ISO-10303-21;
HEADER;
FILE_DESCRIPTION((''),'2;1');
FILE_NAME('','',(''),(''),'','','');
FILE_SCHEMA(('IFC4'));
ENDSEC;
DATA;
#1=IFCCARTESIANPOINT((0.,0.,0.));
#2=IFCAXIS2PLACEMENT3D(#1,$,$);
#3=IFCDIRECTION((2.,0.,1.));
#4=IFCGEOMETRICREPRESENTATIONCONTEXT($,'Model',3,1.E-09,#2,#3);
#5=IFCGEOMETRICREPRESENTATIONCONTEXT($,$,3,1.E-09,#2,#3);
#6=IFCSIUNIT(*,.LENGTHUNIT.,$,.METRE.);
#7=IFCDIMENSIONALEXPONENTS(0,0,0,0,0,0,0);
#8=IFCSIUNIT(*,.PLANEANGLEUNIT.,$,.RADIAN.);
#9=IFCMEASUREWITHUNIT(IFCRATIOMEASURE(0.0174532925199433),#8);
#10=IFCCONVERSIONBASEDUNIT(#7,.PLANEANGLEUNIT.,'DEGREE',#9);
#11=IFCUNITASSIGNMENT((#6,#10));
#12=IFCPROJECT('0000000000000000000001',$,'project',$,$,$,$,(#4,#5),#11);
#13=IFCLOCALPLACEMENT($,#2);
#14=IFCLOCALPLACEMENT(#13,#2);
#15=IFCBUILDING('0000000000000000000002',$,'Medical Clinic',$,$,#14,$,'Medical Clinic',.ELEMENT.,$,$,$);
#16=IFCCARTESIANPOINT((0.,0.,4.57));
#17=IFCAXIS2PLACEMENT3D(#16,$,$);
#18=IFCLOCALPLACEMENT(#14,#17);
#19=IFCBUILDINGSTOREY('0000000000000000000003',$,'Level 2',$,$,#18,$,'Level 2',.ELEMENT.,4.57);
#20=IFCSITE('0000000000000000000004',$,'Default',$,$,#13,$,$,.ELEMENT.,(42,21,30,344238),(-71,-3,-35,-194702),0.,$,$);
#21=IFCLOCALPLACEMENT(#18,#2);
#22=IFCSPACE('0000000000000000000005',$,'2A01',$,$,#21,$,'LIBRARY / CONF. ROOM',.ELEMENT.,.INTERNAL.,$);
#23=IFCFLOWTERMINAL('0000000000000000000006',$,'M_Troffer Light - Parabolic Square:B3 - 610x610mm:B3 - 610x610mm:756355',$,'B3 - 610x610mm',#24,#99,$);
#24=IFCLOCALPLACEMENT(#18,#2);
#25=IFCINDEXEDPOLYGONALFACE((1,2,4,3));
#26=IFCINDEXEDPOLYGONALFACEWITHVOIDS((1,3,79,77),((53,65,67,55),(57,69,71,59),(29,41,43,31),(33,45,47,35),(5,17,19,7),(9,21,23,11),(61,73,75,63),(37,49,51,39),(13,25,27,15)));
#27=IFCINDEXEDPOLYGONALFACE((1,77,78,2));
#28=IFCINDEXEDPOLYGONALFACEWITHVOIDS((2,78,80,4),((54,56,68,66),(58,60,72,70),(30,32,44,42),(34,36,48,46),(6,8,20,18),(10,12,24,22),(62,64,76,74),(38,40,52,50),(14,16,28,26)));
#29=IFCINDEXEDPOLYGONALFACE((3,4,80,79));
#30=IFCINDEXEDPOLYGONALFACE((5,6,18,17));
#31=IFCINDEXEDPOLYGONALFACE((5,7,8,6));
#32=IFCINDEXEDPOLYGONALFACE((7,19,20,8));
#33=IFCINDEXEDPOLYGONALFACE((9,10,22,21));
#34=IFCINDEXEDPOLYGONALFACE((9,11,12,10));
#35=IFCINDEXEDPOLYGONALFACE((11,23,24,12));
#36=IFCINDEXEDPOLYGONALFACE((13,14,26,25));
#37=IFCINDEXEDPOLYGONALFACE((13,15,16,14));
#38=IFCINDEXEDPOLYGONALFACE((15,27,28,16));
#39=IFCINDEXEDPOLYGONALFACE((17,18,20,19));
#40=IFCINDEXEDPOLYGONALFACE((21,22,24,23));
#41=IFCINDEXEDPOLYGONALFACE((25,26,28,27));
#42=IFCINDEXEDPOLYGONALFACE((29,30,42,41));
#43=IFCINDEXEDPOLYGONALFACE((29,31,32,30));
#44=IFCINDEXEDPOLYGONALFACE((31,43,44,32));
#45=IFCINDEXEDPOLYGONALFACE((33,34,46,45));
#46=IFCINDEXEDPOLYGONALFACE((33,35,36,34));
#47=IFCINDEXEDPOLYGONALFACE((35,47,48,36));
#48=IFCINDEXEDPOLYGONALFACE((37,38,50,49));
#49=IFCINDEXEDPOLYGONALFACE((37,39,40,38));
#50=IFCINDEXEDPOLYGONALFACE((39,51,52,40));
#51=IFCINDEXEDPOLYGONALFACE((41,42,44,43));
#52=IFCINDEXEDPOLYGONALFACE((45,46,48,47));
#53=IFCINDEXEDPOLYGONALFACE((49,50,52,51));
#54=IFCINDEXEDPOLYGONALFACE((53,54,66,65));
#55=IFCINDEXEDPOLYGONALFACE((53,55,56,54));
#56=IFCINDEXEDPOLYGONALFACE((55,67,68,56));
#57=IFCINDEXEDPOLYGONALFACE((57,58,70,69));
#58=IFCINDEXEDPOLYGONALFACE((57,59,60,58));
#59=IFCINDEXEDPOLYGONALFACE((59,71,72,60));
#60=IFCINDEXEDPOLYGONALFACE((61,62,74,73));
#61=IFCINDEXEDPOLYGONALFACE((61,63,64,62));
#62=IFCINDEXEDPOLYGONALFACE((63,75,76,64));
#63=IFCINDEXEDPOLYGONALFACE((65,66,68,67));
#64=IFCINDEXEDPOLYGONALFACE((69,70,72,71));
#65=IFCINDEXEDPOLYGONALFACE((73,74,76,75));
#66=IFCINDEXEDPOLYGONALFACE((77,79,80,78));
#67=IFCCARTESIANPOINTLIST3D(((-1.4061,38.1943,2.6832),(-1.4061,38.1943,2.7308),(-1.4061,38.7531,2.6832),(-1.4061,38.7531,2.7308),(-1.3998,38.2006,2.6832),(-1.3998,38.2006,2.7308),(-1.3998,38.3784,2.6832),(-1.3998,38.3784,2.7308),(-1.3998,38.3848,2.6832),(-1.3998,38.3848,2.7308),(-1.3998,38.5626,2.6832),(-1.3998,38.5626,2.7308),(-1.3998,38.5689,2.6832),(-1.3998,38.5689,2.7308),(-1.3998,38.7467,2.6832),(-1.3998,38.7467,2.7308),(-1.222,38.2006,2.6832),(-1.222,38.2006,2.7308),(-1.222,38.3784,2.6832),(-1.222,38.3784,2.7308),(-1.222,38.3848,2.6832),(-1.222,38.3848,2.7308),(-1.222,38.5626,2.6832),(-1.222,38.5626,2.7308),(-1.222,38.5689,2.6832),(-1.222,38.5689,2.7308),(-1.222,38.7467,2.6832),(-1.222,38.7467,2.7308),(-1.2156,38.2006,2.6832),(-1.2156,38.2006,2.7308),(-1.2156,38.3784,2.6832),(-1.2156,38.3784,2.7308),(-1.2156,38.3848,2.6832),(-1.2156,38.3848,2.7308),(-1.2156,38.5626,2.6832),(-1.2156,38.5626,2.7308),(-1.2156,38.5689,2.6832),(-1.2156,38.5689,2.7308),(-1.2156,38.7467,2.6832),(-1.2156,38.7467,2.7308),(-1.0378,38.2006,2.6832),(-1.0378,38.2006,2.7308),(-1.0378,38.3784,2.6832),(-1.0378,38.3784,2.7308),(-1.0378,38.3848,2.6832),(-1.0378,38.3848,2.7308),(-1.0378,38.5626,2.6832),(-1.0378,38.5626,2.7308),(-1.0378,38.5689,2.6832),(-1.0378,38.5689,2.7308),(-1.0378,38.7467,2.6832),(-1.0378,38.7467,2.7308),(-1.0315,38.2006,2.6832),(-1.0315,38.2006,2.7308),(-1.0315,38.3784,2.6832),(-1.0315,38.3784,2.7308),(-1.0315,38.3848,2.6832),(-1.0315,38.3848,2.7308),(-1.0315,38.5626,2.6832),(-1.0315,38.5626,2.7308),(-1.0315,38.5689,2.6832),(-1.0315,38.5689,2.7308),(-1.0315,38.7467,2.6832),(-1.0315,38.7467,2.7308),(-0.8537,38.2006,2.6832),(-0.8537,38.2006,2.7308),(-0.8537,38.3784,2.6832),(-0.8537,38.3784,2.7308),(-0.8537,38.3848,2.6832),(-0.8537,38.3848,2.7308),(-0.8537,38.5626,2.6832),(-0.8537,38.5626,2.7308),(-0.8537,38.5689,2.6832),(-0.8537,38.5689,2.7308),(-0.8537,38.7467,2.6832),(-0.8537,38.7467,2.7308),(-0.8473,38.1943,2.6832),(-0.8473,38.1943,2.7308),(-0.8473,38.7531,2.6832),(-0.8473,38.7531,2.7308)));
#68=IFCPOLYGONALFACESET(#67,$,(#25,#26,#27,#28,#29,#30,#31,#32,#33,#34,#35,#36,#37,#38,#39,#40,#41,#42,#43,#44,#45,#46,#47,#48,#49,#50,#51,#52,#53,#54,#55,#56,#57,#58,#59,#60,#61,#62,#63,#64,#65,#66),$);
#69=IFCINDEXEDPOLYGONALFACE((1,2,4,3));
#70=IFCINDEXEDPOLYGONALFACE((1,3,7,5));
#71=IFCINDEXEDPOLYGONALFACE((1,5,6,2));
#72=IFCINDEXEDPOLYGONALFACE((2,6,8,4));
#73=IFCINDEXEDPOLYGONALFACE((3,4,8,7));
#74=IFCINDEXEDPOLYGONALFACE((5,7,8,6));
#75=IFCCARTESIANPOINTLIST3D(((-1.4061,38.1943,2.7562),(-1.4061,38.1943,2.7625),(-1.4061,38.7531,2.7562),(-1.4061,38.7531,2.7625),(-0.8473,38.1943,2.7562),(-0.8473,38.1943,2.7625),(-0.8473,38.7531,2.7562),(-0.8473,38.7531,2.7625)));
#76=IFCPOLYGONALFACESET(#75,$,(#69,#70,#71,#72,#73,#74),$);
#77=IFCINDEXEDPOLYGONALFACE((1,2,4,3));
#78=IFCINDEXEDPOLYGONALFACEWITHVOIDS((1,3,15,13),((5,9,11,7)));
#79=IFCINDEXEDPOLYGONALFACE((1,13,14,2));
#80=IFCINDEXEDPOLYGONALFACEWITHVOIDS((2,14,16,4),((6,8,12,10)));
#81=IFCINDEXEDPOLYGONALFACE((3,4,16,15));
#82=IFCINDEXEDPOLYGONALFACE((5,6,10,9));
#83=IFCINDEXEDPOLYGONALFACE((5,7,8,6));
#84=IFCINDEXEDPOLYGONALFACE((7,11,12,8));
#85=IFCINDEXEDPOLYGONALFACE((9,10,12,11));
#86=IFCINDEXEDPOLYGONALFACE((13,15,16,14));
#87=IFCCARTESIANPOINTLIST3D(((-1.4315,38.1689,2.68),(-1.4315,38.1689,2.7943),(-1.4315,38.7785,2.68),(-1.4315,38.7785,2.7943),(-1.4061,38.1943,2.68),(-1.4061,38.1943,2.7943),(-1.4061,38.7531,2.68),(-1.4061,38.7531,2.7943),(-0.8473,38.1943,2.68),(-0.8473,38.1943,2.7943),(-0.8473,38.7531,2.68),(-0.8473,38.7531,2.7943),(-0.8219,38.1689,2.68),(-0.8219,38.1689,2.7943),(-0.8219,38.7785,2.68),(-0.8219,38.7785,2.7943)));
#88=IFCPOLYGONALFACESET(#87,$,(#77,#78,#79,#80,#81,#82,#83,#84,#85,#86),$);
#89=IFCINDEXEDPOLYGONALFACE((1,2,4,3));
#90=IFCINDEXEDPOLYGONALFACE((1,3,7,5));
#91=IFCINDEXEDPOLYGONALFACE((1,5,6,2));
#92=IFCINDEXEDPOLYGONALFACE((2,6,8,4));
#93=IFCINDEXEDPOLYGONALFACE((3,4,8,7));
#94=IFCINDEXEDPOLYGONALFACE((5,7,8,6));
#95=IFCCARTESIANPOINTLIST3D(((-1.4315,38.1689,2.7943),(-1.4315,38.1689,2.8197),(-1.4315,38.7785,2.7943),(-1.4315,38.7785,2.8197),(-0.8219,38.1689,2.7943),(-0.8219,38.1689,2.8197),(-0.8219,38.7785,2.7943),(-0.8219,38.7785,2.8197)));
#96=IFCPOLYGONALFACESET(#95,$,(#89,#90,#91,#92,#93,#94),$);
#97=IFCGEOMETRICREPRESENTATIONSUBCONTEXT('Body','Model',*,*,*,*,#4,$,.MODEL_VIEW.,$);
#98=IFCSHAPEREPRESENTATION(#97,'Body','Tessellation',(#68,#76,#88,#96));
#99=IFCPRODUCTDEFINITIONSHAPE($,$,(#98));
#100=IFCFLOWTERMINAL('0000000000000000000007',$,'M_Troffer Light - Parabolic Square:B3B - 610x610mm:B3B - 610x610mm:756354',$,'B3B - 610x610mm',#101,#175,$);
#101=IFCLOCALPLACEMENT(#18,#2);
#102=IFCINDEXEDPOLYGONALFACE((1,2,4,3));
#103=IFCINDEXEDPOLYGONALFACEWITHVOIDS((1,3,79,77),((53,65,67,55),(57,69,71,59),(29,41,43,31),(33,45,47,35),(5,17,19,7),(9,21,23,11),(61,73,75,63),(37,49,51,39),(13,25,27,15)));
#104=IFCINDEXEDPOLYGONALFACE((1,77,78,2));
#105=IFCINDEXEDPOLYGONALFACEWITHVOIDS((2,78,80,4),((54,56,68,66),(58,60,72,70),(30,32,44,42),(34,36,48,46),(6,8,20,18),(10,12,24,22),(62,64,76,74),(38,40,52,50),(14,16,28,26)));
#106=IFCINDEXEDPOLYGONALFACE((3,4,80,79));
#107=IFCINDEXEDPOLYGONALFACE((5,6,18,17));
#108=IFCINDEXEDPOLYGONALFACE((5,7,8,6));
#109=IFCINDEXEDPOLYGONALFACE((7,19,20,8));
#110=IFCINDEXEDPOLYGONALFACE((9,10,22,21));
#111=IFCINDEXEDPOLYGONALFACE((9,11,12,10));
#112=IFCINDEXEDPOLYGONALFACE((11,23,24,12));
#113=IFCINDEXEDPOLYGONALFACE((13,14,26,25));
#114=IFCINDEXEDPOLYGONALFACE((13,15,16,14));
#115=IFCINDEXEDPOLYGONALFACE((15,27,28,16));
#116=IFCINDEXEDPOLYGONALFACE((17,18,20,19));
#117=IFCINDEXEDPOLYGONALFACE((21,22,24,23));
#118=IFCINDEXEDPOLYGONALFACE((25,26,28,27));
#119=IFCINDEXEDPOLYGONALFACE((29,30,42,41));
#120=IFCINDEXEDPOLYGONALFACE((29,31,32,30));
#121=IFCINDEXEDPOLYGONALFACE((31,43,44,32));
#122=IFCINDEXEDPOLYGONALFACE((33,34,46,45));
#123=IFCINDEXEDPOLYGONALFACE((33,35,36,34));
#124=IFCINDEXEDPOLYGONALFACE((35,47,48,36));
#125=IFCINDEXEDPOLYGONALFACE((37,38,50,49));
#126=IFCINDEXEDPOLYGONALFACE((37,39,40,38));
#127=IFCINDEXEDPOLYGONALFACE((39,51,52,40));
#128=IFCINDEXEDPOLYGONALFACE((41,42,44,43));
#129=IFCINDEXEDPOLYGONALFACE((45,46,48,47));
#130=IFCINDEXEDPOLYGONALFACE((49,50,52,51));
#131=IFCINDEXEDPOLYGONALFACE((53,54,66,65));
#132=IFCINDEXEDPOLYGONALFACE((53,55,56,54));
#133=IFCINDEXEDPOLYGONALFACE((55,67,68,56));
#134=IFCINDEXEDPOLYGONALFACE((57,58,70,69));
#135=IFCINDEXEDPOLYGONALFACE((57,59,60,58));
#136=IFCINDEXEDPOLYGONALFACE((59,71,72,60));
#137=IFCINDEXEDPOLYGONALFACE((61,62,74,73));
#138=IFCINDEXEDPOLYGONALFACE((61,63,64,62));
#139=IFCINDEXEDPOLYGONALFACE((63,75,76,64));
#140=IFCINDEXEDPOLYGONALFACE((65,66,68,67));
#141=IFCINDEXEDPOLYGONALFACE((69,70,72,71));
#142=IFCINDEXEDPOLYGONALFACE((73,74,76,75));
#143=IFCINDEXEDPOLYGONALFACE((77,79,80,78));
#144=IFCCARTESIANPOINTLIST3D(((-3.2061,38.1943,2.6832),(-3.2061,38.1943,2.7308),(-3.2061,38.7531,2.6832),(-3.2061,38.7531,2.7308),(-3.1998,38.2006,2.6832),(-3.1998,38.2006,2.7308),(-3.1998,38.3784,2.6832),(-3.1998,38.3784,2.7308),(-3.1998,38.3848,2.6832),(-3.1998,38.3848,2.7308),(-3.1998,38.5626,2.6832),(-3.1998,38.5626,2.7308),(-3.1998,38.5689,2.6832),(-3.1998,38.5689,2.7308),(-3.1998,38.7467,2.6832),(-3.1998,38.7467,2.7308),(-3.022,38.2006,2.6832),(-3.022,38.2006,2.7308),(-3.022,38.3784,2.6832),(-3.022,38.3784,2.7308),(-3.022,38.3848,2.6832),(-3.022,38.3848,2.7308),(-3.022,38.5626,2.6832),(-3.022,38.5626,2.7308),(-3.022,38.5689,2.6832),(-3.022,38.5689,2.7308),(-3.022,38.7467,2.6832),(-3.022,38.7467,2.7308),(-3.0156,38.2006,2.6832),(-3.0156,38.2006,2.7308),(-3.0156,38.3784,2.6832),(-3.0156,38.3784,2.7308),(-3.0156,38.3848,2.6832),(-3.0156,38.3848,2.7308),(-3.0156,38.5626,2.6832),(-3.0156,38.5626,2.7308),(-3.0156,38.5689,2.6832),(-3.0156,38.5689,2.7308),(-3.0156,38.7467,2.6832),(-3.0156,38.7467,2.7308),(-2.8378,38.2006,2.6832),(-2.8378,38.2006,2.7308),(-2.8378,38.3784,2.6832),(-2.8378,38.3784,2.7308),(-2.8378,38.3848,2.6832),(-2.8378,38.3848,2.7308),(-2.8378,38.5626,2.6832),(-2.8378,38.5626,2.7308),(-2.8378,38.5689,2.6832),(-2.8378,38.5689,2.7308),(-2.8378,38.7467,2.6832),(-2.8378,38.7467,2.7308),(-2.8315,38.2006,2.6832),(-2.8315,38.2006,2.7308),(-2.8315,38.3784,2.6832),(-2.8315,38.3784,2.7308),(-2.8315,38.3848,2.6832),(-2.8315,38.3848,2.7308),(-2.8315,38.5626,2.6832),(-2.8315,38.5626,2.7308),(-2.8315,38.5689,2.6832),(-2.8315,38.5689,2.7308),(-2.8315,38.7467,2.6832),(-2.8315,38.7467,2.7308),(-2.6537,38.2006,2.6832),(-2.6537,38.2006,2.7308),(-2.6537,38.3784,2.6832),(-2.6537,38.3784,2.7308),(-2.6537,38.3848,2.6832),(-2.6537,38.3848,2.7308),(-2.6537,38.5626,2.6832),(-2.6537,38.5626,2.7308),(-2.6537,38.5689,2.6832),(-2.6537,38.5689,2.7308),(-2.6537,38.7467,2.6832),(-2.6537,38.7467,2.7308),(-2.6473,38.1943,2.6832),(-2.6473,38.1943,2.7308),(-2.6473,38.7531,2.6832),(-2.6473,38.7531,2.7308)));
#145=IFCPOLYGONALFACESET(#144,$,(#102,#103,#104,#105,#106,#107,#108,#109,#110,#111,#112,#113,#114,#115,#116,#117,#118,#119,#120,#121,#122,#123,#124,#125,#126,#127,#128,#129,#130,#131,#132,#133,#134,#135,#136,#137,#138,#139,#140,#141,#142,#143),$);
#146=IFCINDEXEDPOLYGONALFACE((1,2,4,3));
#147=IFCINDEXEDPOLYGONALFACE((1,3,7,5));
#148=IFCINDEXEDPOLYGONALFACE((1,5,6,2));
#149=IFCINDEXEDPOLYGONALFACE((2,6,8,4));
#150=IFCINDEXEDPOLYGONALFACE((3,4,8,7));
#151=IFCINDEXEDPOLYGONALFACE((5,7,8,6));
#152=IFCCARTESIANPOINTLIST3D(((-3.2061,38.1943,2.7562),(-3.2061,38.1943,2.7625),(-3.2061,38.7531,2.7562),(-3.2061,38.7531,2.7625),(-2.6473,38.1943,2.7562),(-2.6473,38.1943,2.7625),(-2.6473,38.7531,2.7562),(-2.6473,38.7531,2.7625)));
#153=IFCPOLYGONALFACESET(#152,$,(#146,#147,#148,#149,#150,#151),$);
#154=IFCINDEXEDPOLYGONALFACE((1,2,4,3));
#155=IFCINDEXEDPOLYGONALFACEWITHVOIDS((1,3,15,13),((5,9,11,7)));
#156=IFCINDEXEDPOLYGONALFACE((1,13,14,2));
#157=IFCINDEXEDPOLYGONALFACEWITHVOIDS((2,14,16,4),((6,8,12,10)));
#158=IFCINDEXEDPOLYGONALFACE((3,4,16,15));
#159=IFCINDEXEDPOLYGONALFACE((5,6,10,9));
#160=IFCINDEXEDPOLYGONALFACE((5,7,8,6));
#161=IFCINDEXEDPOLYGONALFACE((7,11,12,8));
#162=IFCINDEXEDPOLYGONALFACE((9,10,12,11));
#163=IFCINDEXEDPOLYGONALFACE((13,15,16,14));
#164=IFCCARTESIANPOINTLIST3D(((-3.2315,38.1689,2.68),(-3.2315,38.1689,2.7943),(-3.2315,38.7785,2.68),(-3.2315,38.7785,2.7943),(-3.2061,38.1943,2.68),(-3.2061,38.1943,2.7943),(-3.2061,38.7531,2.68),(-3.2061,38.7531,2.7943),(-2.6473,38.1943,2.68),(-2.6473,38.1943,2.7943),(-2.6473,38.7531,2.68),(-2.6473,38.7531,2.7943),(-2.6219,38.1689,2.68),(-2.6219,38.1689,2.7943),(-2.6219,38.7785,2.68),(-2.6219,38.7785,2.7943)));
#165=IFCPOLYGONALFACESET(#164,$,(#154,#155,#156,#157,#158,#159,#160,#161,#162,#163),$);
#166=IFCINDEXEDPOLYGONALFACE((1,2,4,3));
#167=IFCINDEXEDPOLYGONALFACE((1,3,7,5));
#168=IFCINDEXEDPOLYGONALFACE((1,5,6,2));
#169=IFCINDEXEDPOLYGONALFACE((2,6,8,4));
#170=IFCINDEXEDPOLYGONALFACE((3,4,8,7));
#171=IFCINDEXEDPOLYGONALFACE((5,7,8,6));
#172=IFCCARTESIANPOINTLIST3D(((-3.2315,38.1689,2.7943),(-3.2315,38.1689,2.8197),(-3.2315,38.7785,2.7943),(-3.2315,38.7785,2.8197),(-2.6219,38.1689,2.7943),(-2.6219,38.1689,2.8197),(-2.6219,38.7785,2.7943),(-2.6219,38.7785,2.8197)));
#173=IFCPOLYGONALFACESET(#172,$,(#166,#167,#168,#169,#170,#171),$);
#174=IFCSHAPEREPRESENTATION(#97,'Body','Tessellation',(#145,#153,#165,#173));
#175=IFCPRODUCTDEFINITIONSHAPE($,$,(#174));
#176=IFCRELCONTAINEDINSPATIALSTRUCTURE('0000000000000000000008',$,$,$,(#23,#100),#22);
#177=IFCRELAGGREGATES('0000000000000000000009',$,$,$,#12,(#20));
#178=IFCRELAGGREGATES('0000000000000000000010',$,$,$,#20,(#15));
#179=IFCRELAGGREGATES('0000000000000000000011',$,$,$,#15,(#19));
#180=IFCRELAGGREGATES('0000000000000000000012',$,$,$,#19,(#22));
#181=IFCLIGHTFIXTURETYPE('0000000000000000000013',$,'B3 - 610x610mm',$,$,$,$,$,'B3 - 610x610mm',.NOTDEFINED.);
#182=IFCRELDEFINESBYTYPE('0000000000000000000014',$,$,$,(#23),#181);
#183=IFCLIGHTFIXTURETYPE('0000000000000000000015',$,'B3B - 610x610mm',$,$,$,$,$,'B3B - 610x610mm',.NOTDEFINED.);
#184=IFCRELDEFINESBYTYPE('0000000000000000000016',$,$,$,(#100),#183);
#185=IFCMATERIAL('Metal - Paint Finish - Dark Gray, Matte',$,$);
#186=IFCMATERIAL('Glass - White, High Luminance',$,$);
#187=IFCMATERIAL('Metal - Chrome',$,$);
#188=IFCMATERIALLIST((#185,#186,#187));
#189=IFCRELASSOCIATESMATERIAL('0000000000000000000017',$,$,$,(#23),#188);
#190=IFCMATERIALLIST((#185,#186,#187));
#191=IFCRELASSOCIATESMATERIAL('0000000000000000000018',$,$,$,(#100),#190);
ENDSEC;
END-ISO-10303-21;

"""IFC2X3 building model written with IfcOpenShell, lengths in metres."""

from ifc_helpers import new_model, entity, si_unit, converted_unit, direction, frame, origin, origin_2d_with_axis, place, context, subcontext, project, spatial, polyline, rectangle, outline, extrude, source, transform, mapped, material, material_list, type_object, type_shapes, element, save


model = new_model("IFC2X3")

# Units and contexts
model_context = context("Model", 3, precision=1e-09, world=origin(), true_north=direction((2.0, 0.0, 1.0)))
context_of_model = context(None, 3, precision=1e-09, world=origin(), true_north=direction((2.0, 0.0, 1.0)))
body_context = subcontext(model_context, "Body", "Model", "MODEL_VIEW")
ifc_project = project(units=[si_unit("LENGTHUNIT", "METRE"), converted_unit("PLANEANGLEUNIT", "DEGREE", entity("IfcRatioMeasure", 0.0174532925199433), si_unit("PLANEANGLEUNIT", "RADIAN"), dimensions=[0, 0, 0, 0, 0, 0, 0])], contexts=[model_context, context_of_model])

# Site, building, storey, space
site_placement = place(None, origin())
site = spatial("IfcSite", under=ifc_project, at=site_placement, Name="Default", CompositionType="ELEMENT", RefLatitude=(42, 21, 30, 344238), RefLongitude=(-71, -3, -35, -194702), RefElevation=0.0)
building_placement = place(site_placement, origin())
building = spatial("IfcBuilding", under=site, at=building_placement, Name="Medical Clinic", LongName="Medical Clinic", CompositionType="ELEMENT")
storey_placement = place(building_placement, frame((0.0, 0.0, 4.57)))
storey = spatial("IfcBuildingStorey", under=building, at=storey_placement, Name="Level 2", LongName="Level 2", CompositionType="ELEMENT", Elevation=4.57)
space_1_placement = place(storey_placement, origin())
space_1 = spatial("IfcSpace", under=storey, at=space_1_placement, Name="2A01", LongName="LIBRARY / CONF. ROOM", CompositionType="ELEMENT", InteriorOrExteriorSpace="INTERNAL")

# Flow terminals
ifc_material_1 = material(Name="Metal - Paint Finish - Dark Gray, Matte")
ifc_material_2 = material(Name="Glass - White, High Luminance")
ifc_material_3 = material(Name="Metal - Chrome")
light_fixture_type_1 = type_object("IfcLightFixtureType", Name="B3 - 610x610mm", ElementType="B3 - 610x610mm", PredefinedType="NOTDEFINED")
shared_shape_1 = source(origin(), body_context, "Body", "SweptSolid", [
    extrude(outline(polyline([(-0.2794, -0.2794), (0.2794, -0.2794), (0.2794, 0.2794), (-0.2794, 0.2794), (-0.2794, -0.2794)]), holes=[polyline([(-0.0952, 0.0953), (-0.273, 0.0953), (-0.273, 0.2731), (-0.0952, 0.2731), (-0.0952, 0.0953)]), polyline([(0.2731, 0.0953), (0.0953, 0.0953), (0.0953, 0.2731), (0.2731, 0.2731), (0.2731, 0.0953)]), polyline([(-0.0889, 0.2731), (0.0889, 0.2731), (0.0889, 0.0953), (-0.0889, 0.0953), (-0.0889, 0.2731)]), polyline([(0.2731, -0.273), (0.0953, -0.273), (0.0953, -0.0952), (0.2731, -0.0952), (0.2731, -0.273)]), polyline([(0.0889, -0.273), (-0.0889, -0.273), (-0.0889, -0.0952), (0.0889, -0.0952), (0.0889, -0.273)]), polyline([(-0.0952, -0.273), (-0.273, -0.273), (-0.273, -0.0952), (-0.0952, -0.0952), (-0.0952, -0.273)]), polyline([(-0.0952, -0.0889), (-0.273, -0.0889), (-0.273, 0.0889), (-0.0952, 0.0889), (-0.0952, -0.0889)]), polyline([(0.0889, -0.0889), (-0.0889, -0.0889), (-0.0889, 0.0889), (0.0889, 0.0889), (0.0889, -0.0889)]), polyline([(0.2731, -0.0889), (0.0953, -0.0889), (0.0953, 0.0889), (0.2731, 0.0889), (0.2731, -0.0889)])]), frame((0.0, -0.3048, -0.0508), z_axis=(0.0, 0.0, 1.0), x_axis=(-1.0, 0.0, 0.0)), (0.0, 0.0, 1.0), 0.0476),
    extrude(rectangle(XDim=0.5588, YDim=0.5588, at=origin_2d_with_axis()), frame((0.0, -0.3048, -0.0825), z_axis=(0.0, 0.0, 1.0), x_axis=(-1.0, 0.0, 0.0)), (0.0, 0.0, 1.0), 0.0064),
    extrude(outline(polyline([(-0.3048, -0.3048), (0.3048, -0.3048), (0.3048, 0.3048), (-0.3048, 0.3048), (-0.3048, -0.3048)]), holes=[polyline([(0.2794, 0.2794), (0.2794, -0.2794), (-0.2794, -0.2794), (-0.2794, 0.2794), (0.2794, 0.2794)])]), frame((0.0, -0.3048, -0.1143)), (0.0, 0.0, 1.0), 0.1143),
    extrude(rectangle(XDim=0.6096, YDim=0.6096, at=origin_2d_with_axis()), frame((0.0, -0.3048, -0.1397), z_axis=(0.0, 0.0, 1.0), x_axis=(-1.0, 0.0, 0.0)), (0.0, 0.0, 1.0), 0.0254),
])
type_shapes(light_fixture_type_1, [shared_shape_1])
ifc_material_list_1 = material_list([ifc_material_1, ifc_material_2, ifc_material_3])
flow_terminal_1_placement = place(space_1_placement, frame((-1.1267, 38.1689, 2.68), z_axis=(0.0, 0.0, -1.0), x_axis=(1.0, 0.0, 0.0)))
element("IfcFlowTerminal", 1, at=flow_terminal_1_placement, inside=space_1, type_object=light_fixture_type_1, material=ifc_material_list_1, Name="M_Troffer Light - Parabolic Square:B3 - 610x610mm:B3 - 610x610mm:756355", ObjectType="B3 - 610x610mm", context=body_context, shape_type="MappedRepresentation", body=[
    mapped(shared_shape_1, transform((0.0, 0.0, 0.0), scale=1.0)),
])
ifc_material_list_2 = material_list([ifc_material_1, ifc_material_2, ifc_material_3])
light_fixture_type_2 = type_object("IfcLightFixtureType", Name="B3B - 610x610mm", ElementType="B3B - 610x610mm", PredefinedType="NOTDEFINED")
shared_shape_2 = source(origin(), body_context, "Body", "SweptSolid", [
    extrude(outline(polyline([(-0.2794, -0.2794), (0.2794, -0.2794), (0.2794, 0.2794), (-0.2794, 0.2794), (-0.2794, -0.2794)]), holes=[polyline([(-0.0952, 0.0953), (-0.273, 0.0953), (-0.273, 0.2731), (-0.0952, 0.2731), (-0.0952, 0.0953)]), polyline([(0.2731, 0.0953), (0.0953, 0.0953), (0.0953, 0.2731), (0.2731, 0.2731), (0.2731, 0.0953)]), polyline([(-0.0889, 0.2731), (0.0889, 0.2731), (0.0889, 0.0953), (-0.0889, 0.0953), (-0.0889, 0.2731)]), polyline([(0.2731, -0.273), (0.0953, -0.273), (0.0953, -0.0952), (0.2731, -0.0952), (0.2731, -0.273)]), polyline([(0.0889, -0.273), (-0.0889, -0.273), (-0.0889, -0.0952), (0.0889, -0.0952), (0.0889, -0.273)]), polyline([(-0.0952, -0.273), (-0.273, -0.273), (-0.273, -0.0952), (-0.0952, -0.0952), (-0.0952, -0.273)]), polyline([(-0.0952, -0.0889), (-0.273, -0.0889), (-0.273, 0.0889), (-0.0952, 0.0889), (-0.0952, -0.0889)]), polyline([(0.0889, -0.0889), (-0.0889, -0.0889), (-0.0889, 0.0889), (0.0889, 0.0889), (0.0889, -0.0889)]), polyline([(0.2731, -0.0889), (0.0953, -0.0889), (0.0953, 0.0889), (0.2731, 0.0889), (0.2731, -0.0889)])]), frame((0.0, -0.3048, -0.0508), z_axis=(0.0, 0.0, 1.0), x_axis=(-1.0, 0.0, 0.0)), (0.0, 0.0, 1.0), 0.0476),
    extrude(rectangle(XDim=0.5588, YDim=0.5588, at=origin_2d_with_axis()), frame((0.0, -0.3048, -0.0825), z_axis=(0.0, 0.0, 1.0), x_axis=(-1.0, 0.0, 0.0)), (0.0, 0.0, 1.0), 0.0064),
    extrude(outline(polyline([(-0.3048, -0.3048), (0.3048, -0.3048), (0.3048, 0.3048), (-0.3048, 0.3048), (-0.3048, -0.3048)]), holes=[polyline([(0.2794, 0.2794), (0.2794, -0.2794), (-0.2794, -0.2794), (-0.2794, 0.2794), (0.2794, 0.2794)])]), frame((0.0, -0.3048, -0.1143)), (0.0, 0.0, 1.0), 0.1143),
    extrude(rectangle(XDim=0.6096, YDim=0.6096, at=origin_2d_with_axis()), frame((0.0, -0.3048, -0.1397), z_axis=(0.0, 0.0, 1.0), x_axis=(-1.0, 0.0, 0.0)), (0.0, 0.0, 1.0), 0.0254),
])
type_shapes(light_fixture_type_2, [shared_shape_2])
flow_terminal_2_placement = place(space_1_placement, frame((-2.9267, 38.1689, 2.68), z_axis=(0.0, 0.0, -1.0), x_axis=(1.0, 0.0, 0.0)))
element("IfcFlowTerminal", 2, at=flow_terminal_2_placement, inside=space_1, type_object=light_fixture_type_2, material=ifc_material_list_2, Name="M_Troffer Light - Parabolic Square:B3B - 610x610mm:B3B - 610x610mm:756354", ObjectType="B3B - 610x610mm", context=body_context, shape_type="MappedRepresentation", body=[
    mapped(shared_shape_2, transform((0.0, 0.0, 0.0), scale=1.0)),
])

save(model, "model.ifc")
